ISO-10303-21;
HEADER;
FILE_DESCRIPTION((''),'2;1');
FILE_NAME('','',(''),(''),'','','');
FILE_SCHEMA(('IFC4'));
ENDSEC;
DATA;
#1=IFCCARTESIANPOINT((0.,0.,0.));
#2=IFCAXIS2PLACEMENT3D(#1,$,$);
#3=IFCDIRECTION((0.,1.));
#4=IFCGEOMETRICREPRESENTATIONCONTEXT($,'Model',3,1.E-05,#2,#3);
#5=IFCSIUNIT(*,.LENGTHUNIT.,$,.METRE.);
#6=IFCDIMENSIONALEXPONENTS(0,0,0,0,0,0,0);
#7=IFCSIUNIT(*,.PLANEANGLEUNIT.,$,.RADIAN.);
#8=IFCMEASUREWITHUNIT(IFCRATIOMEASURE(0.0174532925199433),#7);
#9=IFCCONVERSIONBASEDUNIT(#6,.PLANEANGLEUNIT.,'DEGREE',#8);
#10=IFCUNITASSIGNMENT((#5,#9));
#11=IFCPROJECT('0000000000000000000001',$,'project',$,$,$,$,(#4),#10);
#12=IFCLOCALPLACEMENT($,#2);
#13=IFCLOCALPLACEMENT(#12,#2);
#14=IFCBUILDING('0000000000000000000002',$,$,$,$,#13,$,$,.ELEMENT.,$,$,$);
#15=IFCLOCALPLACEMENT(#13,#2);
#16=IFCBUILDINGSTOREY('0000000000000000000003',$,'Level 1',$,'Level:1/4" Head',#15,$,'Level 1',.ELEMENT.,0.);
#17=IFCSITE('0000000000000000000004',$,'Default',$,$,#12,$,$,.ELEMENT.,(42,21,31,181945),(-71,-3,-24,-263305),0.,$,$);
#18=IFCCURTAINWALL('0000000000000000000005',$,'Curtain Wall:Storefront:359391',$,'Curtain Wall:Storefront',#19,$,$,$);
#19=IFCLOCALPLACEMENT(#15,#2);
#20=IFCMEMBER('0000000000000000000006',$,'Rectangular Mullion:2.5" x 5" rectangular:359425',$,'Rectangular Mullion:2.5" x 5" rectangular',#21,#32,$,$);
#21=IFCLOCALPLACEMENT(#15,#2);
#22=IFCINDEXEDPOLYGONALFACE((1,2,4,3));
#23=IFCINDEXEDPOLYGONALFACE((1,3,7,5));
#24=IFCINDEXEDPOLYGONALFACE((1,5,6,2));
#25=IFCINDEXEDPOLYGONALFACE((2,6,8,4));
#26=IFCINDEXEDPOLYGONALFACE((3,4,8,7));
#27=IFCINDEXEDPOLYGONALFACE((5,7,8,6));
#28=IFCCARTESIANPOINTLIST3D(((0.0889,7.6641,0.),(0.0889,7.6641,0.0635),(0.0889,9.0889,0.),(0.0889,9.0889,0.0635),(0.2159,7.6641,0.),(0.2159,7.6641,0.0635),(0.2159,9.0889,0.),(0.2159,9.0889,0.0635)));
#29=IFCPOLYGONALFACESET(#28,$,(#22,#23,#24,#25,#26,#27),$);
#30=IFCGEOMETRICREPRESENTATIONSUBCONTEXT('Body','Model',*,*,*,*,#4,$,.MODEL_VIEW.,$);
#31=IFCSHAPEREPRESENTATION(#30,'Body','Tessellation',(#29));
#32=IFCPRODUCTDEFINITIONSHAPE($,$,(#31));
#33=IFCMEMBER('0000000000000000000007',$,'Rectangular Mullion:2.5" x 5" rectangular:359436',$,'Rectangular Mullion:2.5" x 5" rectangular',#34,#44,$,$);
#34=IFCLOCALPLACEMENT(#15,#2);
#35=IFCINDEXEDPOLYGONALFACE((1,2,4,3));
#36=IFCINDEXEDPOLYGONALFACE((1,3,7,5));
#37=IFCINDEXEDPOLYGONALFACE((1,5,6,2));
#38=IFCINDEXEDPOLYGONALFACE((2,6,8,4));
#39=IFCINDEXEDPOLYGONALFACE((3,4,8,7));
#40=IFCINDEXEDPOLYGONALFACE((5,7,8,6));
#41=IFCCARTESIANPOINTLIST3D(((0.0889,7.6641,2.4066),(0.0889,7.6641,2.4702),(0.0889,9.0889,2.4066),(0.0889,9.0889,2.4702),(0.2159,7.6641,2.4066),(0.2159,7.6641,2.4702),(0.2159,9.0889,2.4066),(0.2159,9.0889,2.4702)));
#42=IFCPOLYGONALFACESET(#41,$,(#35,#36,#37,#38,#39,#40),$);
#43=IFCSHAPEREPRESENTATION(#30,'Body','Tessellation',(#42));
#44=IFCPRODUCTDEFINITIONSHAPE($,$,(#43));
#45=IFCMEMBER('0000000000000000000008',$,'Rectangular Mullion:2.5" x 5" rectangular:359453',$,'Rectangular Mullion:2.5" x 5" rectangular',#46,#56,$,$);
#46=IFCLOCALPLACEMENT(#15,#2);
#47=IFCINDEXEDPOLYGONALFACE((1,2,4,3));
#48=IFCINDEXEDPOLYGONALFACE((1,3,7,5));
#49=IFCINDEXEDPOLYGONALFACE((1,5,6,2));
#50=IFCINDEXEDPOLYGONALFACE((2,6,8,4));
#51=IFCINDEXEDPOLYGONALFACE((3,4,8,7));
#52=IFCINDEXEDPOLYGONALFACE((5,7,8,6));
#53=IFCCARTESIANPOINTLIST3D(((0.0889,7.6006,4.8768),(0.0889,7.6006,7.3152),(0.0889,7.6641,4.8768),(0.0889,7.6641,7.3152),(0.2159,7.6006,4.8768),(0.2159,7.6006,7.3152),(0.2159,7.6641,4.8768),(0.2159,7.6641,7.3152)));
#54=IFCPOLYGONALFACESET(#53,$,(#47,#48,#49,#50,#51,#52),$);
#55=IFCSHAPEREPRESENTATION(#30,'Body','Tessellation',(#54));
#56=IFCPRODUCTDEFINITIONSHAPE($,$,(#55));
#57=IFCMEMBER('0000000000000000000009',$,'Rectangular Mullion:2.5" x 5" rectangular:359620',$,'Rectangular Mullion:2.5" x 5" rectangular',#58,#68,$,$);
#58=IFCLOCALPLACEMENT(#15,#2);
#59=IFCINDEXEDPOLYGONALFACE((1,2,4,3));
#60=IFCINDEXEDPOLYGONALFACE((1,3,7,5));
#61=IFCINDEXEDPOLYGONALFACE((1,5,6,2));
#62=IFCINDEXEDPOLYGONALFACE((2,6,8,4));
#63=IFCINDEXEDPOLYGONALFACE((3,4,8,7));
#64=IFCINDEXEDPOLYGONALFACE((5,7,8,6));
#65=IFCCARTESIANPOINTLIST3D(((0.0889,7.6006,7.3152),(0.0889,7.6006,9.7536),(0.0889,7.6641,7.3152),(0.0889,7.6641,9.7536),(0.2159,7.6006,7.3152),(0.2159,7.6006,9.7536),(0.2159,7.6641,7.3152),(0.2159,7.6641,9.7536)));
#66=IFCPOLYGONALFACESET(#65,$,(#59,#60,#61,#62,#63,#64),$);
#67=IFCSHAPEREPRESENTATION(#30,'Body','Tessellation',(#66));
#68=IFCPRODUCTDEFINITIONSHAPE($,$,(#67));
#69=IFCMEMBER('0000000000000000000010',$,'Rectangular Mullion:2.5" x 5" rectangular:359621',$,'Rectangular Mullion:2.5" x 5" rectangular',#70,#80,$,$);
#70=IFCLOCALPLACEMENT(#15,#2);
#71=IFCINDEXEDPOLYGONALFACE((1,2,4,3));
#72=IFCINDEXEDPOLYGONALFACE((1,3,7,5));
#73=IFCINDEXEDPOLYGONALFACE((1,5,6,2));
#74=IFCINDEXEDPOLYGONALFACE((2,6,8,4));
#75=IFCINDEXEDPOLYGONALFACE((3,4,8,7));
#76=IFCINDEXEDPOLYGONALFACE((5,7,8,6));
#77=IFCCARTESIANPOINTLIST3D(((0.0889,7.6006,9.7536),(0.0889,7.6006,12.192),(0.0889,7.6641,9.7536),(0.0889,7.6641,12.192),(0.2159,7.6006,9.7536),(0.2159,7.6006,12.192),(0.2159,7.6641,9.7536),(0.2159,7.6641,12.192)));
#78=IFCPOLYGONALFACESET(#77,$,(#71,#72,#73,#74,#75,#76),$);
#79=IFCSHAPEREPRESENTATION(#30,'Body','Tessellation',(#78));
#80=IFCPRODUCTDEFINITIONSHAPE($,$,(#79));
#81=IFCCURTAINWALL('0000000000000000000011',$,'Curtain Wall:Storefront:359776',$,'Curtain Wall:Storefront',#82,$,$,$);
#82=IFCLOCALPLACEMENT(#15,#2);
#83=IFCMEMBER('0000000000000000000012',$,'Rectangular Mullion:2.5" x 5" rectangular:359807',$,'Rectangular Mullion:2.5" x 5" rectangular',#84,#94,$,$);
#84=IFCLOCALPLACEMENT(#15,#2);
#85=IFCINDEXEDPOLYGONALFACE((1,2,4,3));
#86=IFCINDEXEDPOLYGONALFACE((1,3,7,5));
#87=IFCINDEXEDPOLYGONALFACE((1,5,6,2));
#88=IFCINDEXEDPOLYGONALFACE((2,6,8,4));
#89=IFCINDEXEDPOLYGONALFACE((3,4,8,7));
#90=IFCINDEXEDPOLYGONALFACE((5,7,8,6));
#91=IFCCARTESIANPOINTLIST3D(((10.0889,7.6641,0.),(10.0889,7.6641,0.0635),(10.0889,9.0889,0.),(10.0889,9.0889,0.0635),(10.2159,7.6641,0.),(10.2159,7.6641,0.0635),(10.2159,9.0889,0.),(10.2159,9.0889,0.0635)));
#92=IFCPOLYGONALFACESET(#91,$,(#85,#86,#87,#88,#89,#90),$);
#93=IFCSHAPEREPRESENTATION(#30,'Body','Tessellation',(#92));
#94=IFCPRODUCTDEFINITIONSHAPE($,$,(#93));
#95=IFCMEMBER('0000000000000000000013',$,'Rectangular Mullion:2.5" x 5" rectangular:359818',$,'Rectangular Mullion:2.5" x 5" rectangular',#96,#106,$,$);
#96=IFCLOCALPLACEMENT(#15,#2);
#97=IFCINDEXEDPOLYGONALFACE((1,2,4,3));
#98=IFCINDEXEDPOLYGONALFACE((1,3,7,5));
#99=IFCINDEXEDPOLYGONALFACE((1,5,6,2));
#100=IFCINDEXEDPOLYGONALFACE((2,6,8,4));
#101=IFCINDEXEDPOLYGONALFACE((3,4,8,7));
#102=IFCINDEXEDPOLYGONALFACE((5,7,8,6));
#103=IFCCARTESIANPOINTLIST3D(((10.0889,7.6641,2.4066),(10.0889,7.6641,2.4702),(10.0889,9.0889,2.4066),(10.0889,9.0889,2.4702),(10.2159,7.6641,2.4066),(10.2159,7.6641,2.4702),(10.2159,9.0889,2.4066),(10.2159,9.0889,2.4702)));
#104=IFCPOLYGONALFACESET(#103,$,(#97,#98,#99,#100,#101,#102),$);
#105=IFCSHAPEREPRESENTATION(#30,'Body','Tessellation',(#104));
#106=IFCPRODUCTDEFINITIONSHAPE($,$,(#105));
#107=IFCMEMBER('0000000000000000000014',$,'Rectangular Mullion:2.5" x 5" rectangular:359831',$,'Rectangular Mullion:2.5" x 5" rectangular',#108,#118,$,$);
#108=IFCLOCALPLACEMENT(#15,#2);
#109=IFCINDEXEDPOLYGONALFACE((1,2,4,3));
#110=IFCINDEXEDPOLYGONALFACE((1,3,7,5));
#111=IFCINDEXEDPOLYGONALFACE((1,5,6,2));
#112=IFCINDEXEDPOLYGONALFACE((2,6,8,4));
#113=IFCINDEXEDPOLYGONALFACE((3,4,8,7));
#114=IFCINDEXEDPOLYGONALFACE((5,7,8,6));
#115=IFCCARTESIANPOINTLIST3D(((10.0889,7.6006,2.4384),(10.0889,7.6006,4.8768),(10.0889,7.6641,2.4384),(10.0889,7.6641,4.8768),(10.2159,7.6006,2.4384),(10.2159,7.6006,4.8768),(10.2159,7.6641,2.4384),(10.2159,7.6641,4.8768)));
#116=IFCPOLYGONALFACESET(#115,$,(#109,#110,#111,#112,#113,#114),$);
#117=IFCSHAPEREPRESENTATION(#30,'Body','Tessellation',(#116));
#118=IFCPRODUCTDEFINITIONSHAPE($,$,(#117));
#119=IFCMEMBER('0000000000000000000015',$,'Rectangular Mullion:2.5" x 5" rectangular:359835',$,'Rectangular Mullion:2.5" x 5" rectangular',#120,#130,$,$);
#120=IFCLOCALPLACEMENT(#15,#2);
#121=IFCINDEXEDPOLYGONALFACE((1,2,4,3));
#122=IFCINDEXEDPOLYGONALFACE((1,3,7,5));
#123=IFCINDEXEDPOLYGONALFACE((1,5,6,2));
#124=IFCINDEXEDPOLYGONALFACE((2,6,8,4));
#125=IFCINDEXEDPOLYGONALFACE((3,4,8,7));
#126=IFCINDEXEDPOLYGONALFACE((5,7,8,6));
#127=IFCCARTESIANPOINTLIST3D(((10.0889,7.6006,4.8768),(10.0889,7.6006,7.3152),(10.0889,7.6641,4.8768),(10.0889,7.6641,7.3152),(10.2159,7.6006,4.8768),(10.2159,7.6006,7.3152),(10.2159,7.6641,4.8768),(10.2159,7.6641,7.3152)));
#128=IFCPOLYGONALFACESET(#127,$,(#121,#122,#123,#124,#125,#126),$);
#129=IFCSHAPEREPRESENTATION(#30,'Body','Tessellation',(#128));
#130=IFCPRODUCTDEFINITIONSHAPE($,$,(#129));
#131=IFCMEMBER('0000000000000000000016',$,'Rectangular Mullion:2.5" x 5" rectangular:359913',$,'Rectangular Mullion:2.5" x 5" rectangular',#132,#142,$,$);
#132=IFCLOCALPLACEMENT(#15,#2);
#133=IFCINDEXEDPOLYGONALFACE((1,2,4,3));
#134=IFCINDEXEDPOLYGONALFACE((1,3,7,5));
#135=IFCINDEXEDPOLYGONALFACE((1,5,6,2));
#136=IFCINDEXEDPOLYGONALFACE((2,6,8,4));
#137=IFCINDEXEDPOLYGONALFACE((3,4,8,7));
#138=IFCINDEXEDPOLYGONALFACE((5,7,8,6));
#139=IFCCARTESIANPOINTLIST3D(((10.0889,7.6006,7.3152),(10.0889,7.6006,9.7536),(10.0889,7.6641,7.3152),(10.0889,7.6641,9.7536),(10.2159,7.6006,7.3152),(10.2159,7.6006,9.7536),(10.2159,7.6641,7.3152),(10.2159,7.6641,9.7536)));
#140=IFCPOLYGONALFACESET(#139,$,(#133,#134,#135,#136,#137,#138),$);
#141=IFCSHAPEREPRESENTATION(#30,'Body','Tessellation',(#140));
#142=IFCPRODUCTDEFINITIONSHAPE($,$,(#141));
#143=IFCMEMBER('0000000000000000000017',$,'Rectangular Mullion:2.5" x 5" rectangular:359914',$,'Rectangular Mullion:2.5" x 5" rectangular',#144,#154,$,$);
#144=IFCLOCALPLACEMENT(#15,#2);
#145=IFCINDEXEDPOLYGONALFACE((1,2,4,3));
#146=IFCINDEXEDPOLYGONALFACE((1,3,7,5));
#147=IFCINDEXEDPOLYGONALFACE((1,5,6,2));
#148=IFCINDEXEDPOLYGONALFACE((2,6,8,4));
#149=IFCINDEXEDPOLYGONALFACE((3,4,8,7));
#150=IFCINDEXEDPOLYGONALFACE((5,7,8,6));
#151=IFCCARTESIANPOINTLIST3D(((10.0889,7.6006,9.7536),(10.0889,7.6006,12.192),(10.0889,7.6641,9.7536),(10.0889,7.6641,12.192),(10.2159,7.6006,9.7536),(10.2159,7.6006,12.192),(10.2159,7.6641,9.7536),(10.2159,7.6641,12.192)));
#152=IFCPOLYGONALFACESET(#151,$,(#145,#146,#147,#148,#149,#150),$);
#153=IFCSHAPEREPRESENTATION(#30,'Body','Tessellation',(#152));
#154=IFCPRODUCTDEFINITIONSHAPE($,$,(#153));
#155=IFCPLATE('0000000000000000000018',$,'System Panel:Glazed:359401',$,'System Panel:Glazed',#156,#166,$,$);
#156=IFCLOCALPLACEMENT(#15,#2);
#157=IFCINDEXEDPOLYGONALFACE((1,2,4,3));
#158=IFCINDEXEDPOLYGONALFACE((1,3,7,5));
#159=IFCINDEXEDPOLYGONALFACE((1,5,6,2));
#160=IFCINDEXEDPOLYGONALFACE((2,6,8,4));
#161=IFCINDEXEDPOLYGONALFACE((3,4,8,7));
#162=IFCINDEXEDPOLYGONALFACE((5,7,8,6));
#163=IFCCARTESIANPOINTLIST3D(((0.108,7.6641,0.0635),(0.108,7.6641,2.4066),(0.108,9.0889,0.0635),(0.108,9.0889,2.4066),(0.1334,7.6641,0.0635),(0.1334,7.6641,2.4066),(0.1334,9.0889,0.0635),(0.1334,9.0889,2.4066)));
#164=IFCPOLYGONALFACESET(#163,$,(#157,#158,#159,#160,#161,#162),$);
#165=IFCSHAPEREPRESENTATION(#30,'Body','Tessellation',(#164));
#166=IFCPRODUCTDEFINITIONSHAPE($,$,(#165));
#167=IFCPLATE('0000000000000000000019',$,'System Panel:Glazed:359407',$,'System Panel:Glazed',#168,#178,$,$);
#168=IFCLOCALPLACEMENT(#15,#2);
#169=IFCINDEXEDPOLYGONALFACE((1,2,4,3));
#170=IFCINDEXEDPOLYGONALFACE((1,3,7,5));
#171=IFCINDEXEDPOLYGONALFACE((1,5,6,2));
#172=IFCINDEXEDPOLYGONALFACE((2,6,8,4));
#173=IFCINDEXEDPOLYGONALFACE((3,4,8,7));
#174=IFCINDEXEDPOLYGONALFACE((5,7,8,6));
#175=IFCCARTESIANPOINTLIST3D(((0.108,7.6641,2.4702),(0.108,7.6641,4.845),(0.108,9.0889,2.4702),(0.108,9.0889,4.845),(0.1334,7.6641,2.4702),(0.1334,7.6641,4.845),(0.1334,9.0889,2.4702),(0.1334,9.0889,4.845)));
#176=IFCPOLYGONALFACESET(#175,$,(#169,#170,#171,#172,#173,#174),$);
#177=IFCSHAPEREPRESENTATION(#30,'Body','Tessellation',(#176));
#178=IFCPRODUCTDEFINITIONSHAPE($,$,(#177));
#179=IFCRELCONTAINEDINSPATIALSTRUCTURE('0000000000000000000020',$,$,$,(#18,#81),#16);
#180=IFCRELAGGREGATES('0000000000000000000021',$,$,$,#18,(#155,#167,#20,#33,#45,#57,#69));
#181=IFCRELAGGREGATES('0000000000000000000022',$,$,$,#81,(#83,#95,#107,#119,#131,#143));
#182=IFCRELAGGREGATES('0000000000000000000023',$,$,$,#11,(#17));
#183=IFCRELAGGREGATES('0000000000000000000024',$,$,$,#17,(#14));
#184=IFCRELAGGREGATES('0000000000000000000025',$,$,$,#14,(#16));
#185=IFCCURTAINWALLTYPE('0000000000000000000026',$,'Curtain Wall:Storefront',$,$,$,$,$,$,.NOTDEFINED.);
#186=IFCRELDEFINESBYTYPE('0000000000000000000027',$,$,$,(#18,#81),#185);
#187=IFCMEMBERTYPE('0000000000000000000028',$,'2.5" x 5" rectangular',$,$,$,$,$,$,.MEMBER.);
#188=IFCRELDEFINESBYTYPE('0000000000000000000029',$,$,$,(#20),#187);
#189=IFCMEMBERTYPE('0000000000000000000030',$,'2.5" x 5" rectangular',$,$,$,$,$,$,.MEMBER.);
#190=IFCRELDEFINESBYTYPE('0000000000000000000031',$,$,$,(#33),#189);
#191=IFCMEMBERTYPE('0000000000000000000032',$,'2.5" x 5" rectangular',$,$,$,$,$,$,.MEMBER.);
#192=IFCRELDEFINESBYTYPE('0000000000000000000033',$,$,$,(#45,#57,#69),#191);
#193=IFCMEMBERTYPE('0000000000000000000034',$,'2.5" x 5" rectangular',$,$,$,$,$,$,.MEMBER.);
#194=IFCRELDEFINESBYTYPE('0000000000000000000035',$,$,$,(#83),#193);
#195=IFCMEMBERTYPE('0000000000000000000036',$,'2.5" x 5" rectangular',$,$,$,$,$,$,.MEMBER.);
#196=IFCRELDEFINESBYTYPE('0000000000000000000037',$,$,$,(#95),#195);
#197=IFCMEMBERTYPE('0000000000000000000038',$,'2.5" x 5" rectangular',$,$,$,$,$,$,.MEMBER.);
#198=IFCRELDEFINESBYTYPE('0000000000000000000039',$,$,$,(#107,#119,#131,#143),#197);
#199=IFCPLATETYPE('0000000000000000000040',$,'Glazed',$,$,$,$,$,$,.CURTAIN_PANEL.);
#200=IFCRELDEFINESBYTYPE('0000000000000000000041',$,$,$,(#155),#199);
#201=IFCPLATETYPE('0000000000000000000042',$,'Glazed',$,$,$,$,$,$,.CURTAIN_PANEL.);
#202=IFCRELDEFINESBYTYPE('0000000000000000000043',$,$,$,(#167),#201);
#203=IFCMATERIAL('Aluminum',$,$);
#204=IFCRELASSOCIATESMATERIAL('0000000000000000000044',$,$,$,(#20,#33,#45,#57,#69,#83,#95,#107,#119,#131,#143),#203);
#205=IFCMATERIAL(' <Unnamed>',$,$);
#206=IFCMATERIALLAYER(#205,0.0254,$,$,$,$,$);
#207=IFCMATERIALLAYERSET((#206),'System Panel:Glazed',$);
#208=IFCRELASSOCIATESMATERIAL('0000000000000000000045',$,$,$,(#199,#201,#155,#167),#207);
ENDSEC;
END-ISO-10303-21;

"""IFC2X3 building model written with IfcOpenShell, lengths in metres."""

from ifc_helpers import new_model, entity, si_unit, converted_unit, direction, frame, frame_2d, origin, origin_2d_with_axis, place, context, subcontext, project, spatial, rectangle, extrude, source, transform, mapped, material, layer, layer_set, layer_usage, type_object, type_shapes, element, aggregate, save


model = new_model("IFC2X3")

# Units and contexts
model_context = context("Model", 3, precision=1e-05, world=origin(), true_north=direction((0.0, 1.0)))
body_context = subcontext(model_context, "Body", "Model", "MODEL_VIEW")
ifc_project = project(units=[si_unit("LENGTHUNIT", "METRE"), converted_unit("PLANEANGLEUNIT", "DEGREE", entity("IfcRatioMeasure", 0.0174532925199433), si_unit("PLANEANGLEUNIT", "RADIAN"), dimensions=[0, 0, 0, 0, 0, 0, 0])], contexts=[model_context])

# Site, building, storey
site_placement = place(None, origin())
site = spatial("IfcSite", under=ifc_project, at=site_placement, Name="Default", CompositionType="ELEMENT", RefLatitude=(42, 21, 31, 181945), RefLongitude=(-71, -3, -24, -263305), RefElevation=0.0)
building_placement = place(site_placement, origin())
building = spatial("IfcBuilding", under=site, at=building_placement, CompositionType="ELEMENT")
storey_placement = place(building_placement, origin())
storey = spatial("IfcBuildingStorey", under=building, at=storey_placement, Name="Level 1", ObjectType="Level:1/4\" Head", LongName="Level 1", CompositionType="ELEMENT", Elevation=0.0)

# Curtain walls, members
curtain_wall_type = type_object("IfcCurtainWallType", Name="Curtain Wall:Storefront", PredefinedType="NOTDEFINED")
curtain_wall_1_placement = place(storey_placement, origin())
curtain_wall_1 = element("IfcCurtainWall", 1, at=curtain_wall_1_placement, inside=storey, type_object=curtain_wall_type, Name="Curtain Wall:Storefront:359391", ObjectType="Curtain Wall:Storefront")
ifc_material_1 = material(Name="Aluminum")
member_type_1 = type_object("IfcMemberType", Name="2.5\" x 5\" rectangular", PredefinedType="MEMBER")
shared_shape_1 = source(origin(), body_context, "Body", "SweptSolid", [
    extrude(rectangle(XDim=0.127, YDim=0.0635, at=origin_2d_with_axis()), frame((-0.0318, 0.0, -1.4248), z_axis=(0.0, 0.0, 1.0), x_axis=(0.0, -1.0, 0.0)), (0.0, 0.0, 1.0), 1.4248),
])
type_shapes(member_type_1, [shared_shape_1])
member_1_placement = place(storey_placement, frame((0.1524, 7.6641, 0.0), z_axis=(0.0, -1.0, 0.0), x_axis=(0.0, 0.0, -1.0)))
member_1 = element("IfcMember", 2, at=member_1_placement, type_object=member_type_1, material=ifc_material_1, Name="Rectangular Mullion:2.5\" x 5\" rectangular:359425", ObjectType="Rectangular Mullion:2.5\" x 5\" rectangular", context=body_context, shape_type="MappedRepresentation", body=[
    mapped(shared_shape_1, transform((0.0, 0.0, 0.0), scale=1.0)),
])
member_type_2 = type_object("IfcMemberType", Name="2.5\" x 5\" rectangular", PredefinedType="MEMBER")
shared_shape_2 = source(origin(), body_context, "Body", "SweptSolid", [
    extrude(rectangle(XDim=0.127, YDim=0.0635, at=origin_2d_with_axis()), frame((0.0, 0.0, -1.4248), z_axis=(0.0, 0.0, 1.0), x_axis=(0.0, -1.0, 0.0)), (0.0, 0.0, 1.0), 1.4248),
])
type_shapes(member_type_2, [shared_shape_2])
member_2_placement = place(storey_placement, frame((0.1524, 9.0889, 2.4384), z_axis=(0.0, 1.0, 0.0), x_axis=(0.0, 0.0, 1.0)))
member_2 = element("IfcMember", 3, at=member_2_placement, type_object=member_type_2, material=ifc_material_1, Name="Rectangular Mullion:2.5\" x 5\" rectangular:359436", ObjectType="Rectangular Mullion:2.5\" x 5\" rectangular", context=body_context, shape_type="MappedRepresentation", body=[
    mapped(shared_shape_2, transform((0.0, 0.0, 0.0), scale=1.0)),
])
member_type_3 = type_object("IfcMemberType", Name="2.5\" x 5\" rectangular", PredefinedType="MEMBER")
shared_shape_3 = source(origin(), body_context, "Body", "SweptSolid", [
    extrude(rectangle(XDim=0.127, YDim=0.0635, at=origin_2d_with_axis()), frame((0.0, 0.0, -2.4384), z_axis=(0.0, 0.0, 1.0), x_axis=(0.0, -1.0, 0.0)), (0.0, 0.0, 1.0), 2.4384),
])
type_shapes(member_type_3, [shared_shape_3])
member_3_placement = place(storey_placement, frame((0.1524, 7.6324, 4.8768), z_axis=(0.0, 0.0, -1.0), x_axis=(0.0, 1.0, 0.0)))
member_3 = element("IfcMember", 4, at=member_3_placement, type_object=member_type_3, material=ifc_material_1, Name="Rectangular Mullion:2.5\" x 5\" rectangular:359453", ObjectType="Rectangular Mullion:2.5\" x 5\" rectangular", context=body_context, shape_type="MappedRepresentation", body=[
    mapped(shared_shape_3, transform((0.0, 0.0, 0.0), scale=1.0)),
])
member_4_placement = place(storey_placement, frame((0.1524, 7.6324, 7.3152), z_axis=(0.0, 0.0, -1.0), x_axis=(0.0, 1.0, 0.0)))
member_4 = element("IfcMember", 5, at=member_4_placement, type_object=member_type_3, material=ifc_material_1, Name="Rectangular Mullion:2.5\" x 5\" rectangular:359620", ObjectType="Rectangular Mullion:2.5\" x 5\" rectangular", context=body_context, shape_type="MappedRepresentation", body=[
    mapped(shared_shape_3, transform((0.0, 0.0, 0.0), scale=1.0)),
])
member_5_placement = place(storey_placement, frame((0.1524, 7.6324, 9.7536), z_axis=(0.0, 0.0, -1.0), x_axis=(0.0, 1.0, 0.0)))
member_5 = element("IfcMember", 6, at=member_5_placement, type_object=member_type_3, material=ifc_material_1, Name="Rectangular Mullion:2.5\" x 5\" rectangular:359621", ObjectType="Rectangular Mullion:2.5\" x 5\" rectangular", context=body_context, shape_type="MappedRepresentation", body=[
    mapped(shared_shape_3, transform((0.0, 0.0, 0.0), scale=1.0)),
])
curtain_wall_2_placement = place(storey_placement, origin())
curtain_wall_2 = element("IfcCurtainWall", 7, at=curtain_wall_2_placement, inside=storey, type_object=curtain_wall_type, Name="Curtain Wall:Storefront:359776", ObjectType="Curtain Wall:Storefront")
member_type_4 = type_object("IfcMemberType", Name="2.5\" x 5\" rectangular", PredefinedType="MEMBER")
shared_shape_4 = source(origin(), body_context, "Body", "SweptSolid", [
    extrude(rectangle(XDim=0.127, YDim=0.0635, at=origin_2d_with_axis()), frame((-0.0318, 0.0, -1.4248), z_axis=(0.0, 0.0, 1.0), x_axis=(0.0, -1.0, 0.0)), (0.0, 0.0, 1.0), 1.4248),
])
type_shapes(member_type_4, [shared_shape_4])
member_6_placement = place(storey_placement, frame((10.1524, 7.6641, 0.0), z_axis=(0.0, -1.0, 0.0), x_axis=(0.0, 0.0, -1.0)))
member_6 = element("IfcMember", 8, at=member_6_placement, type_object=member_type_4, material=ifc_material_1, Name="Rectangular Mullion:2.5\" x 5\" rectangular:359807", ObjectType="Rectangular Mullion:2.5\" x 5\" rectangular", context=body_context, shape_type="MappedRepresentation", body=[
    mapped(shared_shape_4, transform((0.0, 0.0, 0.0), scale=1.0)),
])
member_type_5 = type_object("IfcMemberType", Name="2.5\" x 5\" rectangular", PredefinedType="MEMBER")
shared_shape_5 = source(origin(), body_context, "Body", "SweptSolid", [
    extrude(rectangle(XDim=0.127, YDim=0.0635, at=origin_2d_with_axis()), frame((0.0, 0.0, -1.4248), z_axis=(0.0, 0.0, 1.0), x_axis=(0.0, -1.0, 0.0)), (0.0, 0.0, 1.0), 1.4248),
])
type_shapes(member_type_5, [shared_shape_5])
member_7_placement = place(storey_placement, frame((10.1524, 9.0889, 2.4384), z_axis=(0.0, 1.0, 0.0), x_axis=(0.0, 0.0, 1.0)))
member_7 = element("IfcMember", 9, at=member_7_placement, type_object=member_type_5, material=ifc_material_1, Name="Rectangular Mullion:2.5\" x 5\" rectangular:359818", ObjectType="Rectangular Mullion:2.5\" x 5\" rectangular", context=body_context, shape_type="MappedRepresentation", body=[
    mapped(shared_shape_5, transform((0.0, 0.0, 0.0), scale=1.0)),
])
member_type_6 = type_object("IfcMemberType", Name="2.5\" x 5\" rectangular", PredefinedType="MEMBER")
shared_shape_6 = source(origin(), body_context, "Body", "SweptSolid", [
    extrude(rectangle(XDim=0.127, YDim=0.0635, at=origin_2d_with_axis()), frame((0.0, 0.0, -2.4384), z_axis=(0.0, 0.0, 1.0), x_axis=(0.0, -1.0, 0.0)), (0.0, 0.0, 1.0), 2.4384),
])
type_shapes(member_type_6, [shared_shape_6])
member_8_placement = place(storey_placement, frame((10.1524, 7.6324, 2.4384), z_axis=(0.0, 0.0, -1.0), x_axis=(0.0, 1.0, 0.0)))
member_8 = element("IfcMember", 10, at=member_8_placement, type_object=member_type_6, material=ifc_material_1, Name="Rectangular Mullion:2.5\" x 5\" rectangular:359831", ObjectType="Rectangular Mullion:2.5\" x 5\" rectangular", context=body_context, shape_type="MappedRepresentation", body=[
    mapped(shared_shape_6, transform((0.0, 0.0, 0.0), scale=1.0)),
])
member_9_placement = place(storey_placement, frame((10.1524, 7.6324, 4.8768), z_axis=(0.0, 0.0, -1.0), x_axis=(0.0, 1.0, 0.0)))
member_9 = element("IfcMember", 11, at=member_9_placement, type_object=member_type_6, material=ifc_material_1, Name="Rectangular Mullion:2.5\" x 5\" rectangular:359835", ObjectType="Rectangular Mullion:2.5\" x 5\" rectangular", context=body_context, shape_type="MappedRepresentation", body=[
    mapped(shared_shape_6, transform((0.0, 0.0, 0.0), scale=1.0)),
])
member_10_placement = place(storey_placement, frame((10.1524, 7.6324, 7.3152), z_axis=(0.0, 0.0, -1.0), x_axis=(0.0, 1.0, 0.0)))
member_10 = element("IfcMember", 12, at=member_10_placement, type_object=member_type_6, material=ifc_material_1, Name="Rectangular Mullion:2.5\" x 5\" rectangular:359913", ObjectType="Rectangular Mullion:2.5\" x 5\" rectangular", context=body_context, shape_type="MappedRepresentation", body=[
    mapped(shared_shape_6, transform((0.0, 0.0, 0.0), scale=1.0)),
])
member_11_placement = place(storey_placement, frame((10.1524, 7.6324, 9.7536), z_axis=(0.0, 0.0, -1.0), x_axis=(0.0, 1.0, 0.0)))
member_11 = element("IfcMember", 13, at=member_11_placement, type_object=member_type_6, material=ifc_material_1, Name="Rectangular Mullion:2.5\" x 5\" rectangular:359914", ObjectType="Rectangular Mullion:2.5\" x 5\" rectangular", context=body_context, shape_type="MappedRepresentation", body=[
    mapped(shared_shape_6, transform((0.0, 0.0, 0.0), scale=1.0)),
])

# Plates
ifc_material_2 = material(Name=" <Unnamed>")
ifc_layer = layer(ifc_material_2, 0.0254)
ifc_layer_set = layer_set([ifc_layer], Name="System Panel:Glazed")
ifc_layer_usage_1 = layer_usage(ifc_layer_set, "AXIS3", "POSITIVE", 0.1042)
plate_type_1 = type_object("IfcPlateType", Name="Glazed", PredefinedType="CURTAIN_PANEL", material=ifc_layer_set)
shared_shape_7 = source(origin(), body_context, "Body", "SweptSolid", [
    extrude(rectangle(XDim=0.0254, YDim=1.4248, at=frame_2d((0.0, 0.0), x_axis=(1.0, 0.0))), frame((0.7124, 0.0127, 0.0), z_axis=(0.0, 0.0, 1.0), x_axis=(0.0, 1.0, 0.0)), (0.0, 0.0, 1.0), 2.3432),
])
type_shapes(plate_type_1, [shared_shape_7])
plate_1_placement = place(curtain_wall_1_placement, frame((0.1334, 7.6641, 0.0635), z_axis=(0.0, 0.0, 1.0), x_axis=(0.0, 1.0, 0.0)))
plate_1 = element("IfcPlate", 14, at=plate_1_placement, type_object=plate_type_1, material=ifc_layer_usage_1, Name="System Panel:Glazed:359401", ObjectType="System Panel:Glazed", context=body_context, shape_type="MappedRepresentation", body=[
    mapped(shared_shape_7, transform((0.0, 0.0, 0.0), scale=1.0)),
])
ifc_layer_usage_2 = layer_usage(ifc_layer_set, "AXIS3", "POSITIVE", 0.1042)
plate_type_2 = type_object("IfcPlateType", Name="Glazed", PredefinedType="CURTAIN_PANEL", material=ifc_layer_set)
shared_shape_8 = source(origin(), body_context, "Body", "SweptSolid", [
    extrude(rectangle(XDim=0.0254, YDim=1.4248, at=frame_2d((0.0, 0.0), x_axis=(1.0, 0.0))), frame((0.7124, 0.0127, 0.0), z_axis=(0.0, 0.0, 1.0), x_axis=(0.0, 1.0, 0.0)), (0.0, 0.0, 1.0), 2.3749),
])
type_shapes(plate_type_2, [shared_shape_8])
plate_2_placement = place(curtain_wall_1_placement, frame((0.1334, 7.6641, 2.4701), z_axis=(0.0, 0.0, 1.0), x_axis=(0.0, 1.0, 0.0)))
plate_2 = element("IfcPlate", 15, at=plate_2_placement, type_object=plate_type_2, material=ifc_layer_usage_2, Name="System Panel:Glazed:359407", ObjectType="System Panel:Glazed", context=body_context, shape_type="MappedRepresentation", body=[
    mapped(shared_shape_8, transform((0.0, 0.0, 0.0), scale=1.0)),
])
aggregate(curtain_wall_1, [plate_1, plate_2, member_1, member_2, member_3, member_4, member_5])
aggregate(curtain_wall_2, [member_6, member_7, member_8, member_9, member_10, member_11])

save(model, "model.ifc")
